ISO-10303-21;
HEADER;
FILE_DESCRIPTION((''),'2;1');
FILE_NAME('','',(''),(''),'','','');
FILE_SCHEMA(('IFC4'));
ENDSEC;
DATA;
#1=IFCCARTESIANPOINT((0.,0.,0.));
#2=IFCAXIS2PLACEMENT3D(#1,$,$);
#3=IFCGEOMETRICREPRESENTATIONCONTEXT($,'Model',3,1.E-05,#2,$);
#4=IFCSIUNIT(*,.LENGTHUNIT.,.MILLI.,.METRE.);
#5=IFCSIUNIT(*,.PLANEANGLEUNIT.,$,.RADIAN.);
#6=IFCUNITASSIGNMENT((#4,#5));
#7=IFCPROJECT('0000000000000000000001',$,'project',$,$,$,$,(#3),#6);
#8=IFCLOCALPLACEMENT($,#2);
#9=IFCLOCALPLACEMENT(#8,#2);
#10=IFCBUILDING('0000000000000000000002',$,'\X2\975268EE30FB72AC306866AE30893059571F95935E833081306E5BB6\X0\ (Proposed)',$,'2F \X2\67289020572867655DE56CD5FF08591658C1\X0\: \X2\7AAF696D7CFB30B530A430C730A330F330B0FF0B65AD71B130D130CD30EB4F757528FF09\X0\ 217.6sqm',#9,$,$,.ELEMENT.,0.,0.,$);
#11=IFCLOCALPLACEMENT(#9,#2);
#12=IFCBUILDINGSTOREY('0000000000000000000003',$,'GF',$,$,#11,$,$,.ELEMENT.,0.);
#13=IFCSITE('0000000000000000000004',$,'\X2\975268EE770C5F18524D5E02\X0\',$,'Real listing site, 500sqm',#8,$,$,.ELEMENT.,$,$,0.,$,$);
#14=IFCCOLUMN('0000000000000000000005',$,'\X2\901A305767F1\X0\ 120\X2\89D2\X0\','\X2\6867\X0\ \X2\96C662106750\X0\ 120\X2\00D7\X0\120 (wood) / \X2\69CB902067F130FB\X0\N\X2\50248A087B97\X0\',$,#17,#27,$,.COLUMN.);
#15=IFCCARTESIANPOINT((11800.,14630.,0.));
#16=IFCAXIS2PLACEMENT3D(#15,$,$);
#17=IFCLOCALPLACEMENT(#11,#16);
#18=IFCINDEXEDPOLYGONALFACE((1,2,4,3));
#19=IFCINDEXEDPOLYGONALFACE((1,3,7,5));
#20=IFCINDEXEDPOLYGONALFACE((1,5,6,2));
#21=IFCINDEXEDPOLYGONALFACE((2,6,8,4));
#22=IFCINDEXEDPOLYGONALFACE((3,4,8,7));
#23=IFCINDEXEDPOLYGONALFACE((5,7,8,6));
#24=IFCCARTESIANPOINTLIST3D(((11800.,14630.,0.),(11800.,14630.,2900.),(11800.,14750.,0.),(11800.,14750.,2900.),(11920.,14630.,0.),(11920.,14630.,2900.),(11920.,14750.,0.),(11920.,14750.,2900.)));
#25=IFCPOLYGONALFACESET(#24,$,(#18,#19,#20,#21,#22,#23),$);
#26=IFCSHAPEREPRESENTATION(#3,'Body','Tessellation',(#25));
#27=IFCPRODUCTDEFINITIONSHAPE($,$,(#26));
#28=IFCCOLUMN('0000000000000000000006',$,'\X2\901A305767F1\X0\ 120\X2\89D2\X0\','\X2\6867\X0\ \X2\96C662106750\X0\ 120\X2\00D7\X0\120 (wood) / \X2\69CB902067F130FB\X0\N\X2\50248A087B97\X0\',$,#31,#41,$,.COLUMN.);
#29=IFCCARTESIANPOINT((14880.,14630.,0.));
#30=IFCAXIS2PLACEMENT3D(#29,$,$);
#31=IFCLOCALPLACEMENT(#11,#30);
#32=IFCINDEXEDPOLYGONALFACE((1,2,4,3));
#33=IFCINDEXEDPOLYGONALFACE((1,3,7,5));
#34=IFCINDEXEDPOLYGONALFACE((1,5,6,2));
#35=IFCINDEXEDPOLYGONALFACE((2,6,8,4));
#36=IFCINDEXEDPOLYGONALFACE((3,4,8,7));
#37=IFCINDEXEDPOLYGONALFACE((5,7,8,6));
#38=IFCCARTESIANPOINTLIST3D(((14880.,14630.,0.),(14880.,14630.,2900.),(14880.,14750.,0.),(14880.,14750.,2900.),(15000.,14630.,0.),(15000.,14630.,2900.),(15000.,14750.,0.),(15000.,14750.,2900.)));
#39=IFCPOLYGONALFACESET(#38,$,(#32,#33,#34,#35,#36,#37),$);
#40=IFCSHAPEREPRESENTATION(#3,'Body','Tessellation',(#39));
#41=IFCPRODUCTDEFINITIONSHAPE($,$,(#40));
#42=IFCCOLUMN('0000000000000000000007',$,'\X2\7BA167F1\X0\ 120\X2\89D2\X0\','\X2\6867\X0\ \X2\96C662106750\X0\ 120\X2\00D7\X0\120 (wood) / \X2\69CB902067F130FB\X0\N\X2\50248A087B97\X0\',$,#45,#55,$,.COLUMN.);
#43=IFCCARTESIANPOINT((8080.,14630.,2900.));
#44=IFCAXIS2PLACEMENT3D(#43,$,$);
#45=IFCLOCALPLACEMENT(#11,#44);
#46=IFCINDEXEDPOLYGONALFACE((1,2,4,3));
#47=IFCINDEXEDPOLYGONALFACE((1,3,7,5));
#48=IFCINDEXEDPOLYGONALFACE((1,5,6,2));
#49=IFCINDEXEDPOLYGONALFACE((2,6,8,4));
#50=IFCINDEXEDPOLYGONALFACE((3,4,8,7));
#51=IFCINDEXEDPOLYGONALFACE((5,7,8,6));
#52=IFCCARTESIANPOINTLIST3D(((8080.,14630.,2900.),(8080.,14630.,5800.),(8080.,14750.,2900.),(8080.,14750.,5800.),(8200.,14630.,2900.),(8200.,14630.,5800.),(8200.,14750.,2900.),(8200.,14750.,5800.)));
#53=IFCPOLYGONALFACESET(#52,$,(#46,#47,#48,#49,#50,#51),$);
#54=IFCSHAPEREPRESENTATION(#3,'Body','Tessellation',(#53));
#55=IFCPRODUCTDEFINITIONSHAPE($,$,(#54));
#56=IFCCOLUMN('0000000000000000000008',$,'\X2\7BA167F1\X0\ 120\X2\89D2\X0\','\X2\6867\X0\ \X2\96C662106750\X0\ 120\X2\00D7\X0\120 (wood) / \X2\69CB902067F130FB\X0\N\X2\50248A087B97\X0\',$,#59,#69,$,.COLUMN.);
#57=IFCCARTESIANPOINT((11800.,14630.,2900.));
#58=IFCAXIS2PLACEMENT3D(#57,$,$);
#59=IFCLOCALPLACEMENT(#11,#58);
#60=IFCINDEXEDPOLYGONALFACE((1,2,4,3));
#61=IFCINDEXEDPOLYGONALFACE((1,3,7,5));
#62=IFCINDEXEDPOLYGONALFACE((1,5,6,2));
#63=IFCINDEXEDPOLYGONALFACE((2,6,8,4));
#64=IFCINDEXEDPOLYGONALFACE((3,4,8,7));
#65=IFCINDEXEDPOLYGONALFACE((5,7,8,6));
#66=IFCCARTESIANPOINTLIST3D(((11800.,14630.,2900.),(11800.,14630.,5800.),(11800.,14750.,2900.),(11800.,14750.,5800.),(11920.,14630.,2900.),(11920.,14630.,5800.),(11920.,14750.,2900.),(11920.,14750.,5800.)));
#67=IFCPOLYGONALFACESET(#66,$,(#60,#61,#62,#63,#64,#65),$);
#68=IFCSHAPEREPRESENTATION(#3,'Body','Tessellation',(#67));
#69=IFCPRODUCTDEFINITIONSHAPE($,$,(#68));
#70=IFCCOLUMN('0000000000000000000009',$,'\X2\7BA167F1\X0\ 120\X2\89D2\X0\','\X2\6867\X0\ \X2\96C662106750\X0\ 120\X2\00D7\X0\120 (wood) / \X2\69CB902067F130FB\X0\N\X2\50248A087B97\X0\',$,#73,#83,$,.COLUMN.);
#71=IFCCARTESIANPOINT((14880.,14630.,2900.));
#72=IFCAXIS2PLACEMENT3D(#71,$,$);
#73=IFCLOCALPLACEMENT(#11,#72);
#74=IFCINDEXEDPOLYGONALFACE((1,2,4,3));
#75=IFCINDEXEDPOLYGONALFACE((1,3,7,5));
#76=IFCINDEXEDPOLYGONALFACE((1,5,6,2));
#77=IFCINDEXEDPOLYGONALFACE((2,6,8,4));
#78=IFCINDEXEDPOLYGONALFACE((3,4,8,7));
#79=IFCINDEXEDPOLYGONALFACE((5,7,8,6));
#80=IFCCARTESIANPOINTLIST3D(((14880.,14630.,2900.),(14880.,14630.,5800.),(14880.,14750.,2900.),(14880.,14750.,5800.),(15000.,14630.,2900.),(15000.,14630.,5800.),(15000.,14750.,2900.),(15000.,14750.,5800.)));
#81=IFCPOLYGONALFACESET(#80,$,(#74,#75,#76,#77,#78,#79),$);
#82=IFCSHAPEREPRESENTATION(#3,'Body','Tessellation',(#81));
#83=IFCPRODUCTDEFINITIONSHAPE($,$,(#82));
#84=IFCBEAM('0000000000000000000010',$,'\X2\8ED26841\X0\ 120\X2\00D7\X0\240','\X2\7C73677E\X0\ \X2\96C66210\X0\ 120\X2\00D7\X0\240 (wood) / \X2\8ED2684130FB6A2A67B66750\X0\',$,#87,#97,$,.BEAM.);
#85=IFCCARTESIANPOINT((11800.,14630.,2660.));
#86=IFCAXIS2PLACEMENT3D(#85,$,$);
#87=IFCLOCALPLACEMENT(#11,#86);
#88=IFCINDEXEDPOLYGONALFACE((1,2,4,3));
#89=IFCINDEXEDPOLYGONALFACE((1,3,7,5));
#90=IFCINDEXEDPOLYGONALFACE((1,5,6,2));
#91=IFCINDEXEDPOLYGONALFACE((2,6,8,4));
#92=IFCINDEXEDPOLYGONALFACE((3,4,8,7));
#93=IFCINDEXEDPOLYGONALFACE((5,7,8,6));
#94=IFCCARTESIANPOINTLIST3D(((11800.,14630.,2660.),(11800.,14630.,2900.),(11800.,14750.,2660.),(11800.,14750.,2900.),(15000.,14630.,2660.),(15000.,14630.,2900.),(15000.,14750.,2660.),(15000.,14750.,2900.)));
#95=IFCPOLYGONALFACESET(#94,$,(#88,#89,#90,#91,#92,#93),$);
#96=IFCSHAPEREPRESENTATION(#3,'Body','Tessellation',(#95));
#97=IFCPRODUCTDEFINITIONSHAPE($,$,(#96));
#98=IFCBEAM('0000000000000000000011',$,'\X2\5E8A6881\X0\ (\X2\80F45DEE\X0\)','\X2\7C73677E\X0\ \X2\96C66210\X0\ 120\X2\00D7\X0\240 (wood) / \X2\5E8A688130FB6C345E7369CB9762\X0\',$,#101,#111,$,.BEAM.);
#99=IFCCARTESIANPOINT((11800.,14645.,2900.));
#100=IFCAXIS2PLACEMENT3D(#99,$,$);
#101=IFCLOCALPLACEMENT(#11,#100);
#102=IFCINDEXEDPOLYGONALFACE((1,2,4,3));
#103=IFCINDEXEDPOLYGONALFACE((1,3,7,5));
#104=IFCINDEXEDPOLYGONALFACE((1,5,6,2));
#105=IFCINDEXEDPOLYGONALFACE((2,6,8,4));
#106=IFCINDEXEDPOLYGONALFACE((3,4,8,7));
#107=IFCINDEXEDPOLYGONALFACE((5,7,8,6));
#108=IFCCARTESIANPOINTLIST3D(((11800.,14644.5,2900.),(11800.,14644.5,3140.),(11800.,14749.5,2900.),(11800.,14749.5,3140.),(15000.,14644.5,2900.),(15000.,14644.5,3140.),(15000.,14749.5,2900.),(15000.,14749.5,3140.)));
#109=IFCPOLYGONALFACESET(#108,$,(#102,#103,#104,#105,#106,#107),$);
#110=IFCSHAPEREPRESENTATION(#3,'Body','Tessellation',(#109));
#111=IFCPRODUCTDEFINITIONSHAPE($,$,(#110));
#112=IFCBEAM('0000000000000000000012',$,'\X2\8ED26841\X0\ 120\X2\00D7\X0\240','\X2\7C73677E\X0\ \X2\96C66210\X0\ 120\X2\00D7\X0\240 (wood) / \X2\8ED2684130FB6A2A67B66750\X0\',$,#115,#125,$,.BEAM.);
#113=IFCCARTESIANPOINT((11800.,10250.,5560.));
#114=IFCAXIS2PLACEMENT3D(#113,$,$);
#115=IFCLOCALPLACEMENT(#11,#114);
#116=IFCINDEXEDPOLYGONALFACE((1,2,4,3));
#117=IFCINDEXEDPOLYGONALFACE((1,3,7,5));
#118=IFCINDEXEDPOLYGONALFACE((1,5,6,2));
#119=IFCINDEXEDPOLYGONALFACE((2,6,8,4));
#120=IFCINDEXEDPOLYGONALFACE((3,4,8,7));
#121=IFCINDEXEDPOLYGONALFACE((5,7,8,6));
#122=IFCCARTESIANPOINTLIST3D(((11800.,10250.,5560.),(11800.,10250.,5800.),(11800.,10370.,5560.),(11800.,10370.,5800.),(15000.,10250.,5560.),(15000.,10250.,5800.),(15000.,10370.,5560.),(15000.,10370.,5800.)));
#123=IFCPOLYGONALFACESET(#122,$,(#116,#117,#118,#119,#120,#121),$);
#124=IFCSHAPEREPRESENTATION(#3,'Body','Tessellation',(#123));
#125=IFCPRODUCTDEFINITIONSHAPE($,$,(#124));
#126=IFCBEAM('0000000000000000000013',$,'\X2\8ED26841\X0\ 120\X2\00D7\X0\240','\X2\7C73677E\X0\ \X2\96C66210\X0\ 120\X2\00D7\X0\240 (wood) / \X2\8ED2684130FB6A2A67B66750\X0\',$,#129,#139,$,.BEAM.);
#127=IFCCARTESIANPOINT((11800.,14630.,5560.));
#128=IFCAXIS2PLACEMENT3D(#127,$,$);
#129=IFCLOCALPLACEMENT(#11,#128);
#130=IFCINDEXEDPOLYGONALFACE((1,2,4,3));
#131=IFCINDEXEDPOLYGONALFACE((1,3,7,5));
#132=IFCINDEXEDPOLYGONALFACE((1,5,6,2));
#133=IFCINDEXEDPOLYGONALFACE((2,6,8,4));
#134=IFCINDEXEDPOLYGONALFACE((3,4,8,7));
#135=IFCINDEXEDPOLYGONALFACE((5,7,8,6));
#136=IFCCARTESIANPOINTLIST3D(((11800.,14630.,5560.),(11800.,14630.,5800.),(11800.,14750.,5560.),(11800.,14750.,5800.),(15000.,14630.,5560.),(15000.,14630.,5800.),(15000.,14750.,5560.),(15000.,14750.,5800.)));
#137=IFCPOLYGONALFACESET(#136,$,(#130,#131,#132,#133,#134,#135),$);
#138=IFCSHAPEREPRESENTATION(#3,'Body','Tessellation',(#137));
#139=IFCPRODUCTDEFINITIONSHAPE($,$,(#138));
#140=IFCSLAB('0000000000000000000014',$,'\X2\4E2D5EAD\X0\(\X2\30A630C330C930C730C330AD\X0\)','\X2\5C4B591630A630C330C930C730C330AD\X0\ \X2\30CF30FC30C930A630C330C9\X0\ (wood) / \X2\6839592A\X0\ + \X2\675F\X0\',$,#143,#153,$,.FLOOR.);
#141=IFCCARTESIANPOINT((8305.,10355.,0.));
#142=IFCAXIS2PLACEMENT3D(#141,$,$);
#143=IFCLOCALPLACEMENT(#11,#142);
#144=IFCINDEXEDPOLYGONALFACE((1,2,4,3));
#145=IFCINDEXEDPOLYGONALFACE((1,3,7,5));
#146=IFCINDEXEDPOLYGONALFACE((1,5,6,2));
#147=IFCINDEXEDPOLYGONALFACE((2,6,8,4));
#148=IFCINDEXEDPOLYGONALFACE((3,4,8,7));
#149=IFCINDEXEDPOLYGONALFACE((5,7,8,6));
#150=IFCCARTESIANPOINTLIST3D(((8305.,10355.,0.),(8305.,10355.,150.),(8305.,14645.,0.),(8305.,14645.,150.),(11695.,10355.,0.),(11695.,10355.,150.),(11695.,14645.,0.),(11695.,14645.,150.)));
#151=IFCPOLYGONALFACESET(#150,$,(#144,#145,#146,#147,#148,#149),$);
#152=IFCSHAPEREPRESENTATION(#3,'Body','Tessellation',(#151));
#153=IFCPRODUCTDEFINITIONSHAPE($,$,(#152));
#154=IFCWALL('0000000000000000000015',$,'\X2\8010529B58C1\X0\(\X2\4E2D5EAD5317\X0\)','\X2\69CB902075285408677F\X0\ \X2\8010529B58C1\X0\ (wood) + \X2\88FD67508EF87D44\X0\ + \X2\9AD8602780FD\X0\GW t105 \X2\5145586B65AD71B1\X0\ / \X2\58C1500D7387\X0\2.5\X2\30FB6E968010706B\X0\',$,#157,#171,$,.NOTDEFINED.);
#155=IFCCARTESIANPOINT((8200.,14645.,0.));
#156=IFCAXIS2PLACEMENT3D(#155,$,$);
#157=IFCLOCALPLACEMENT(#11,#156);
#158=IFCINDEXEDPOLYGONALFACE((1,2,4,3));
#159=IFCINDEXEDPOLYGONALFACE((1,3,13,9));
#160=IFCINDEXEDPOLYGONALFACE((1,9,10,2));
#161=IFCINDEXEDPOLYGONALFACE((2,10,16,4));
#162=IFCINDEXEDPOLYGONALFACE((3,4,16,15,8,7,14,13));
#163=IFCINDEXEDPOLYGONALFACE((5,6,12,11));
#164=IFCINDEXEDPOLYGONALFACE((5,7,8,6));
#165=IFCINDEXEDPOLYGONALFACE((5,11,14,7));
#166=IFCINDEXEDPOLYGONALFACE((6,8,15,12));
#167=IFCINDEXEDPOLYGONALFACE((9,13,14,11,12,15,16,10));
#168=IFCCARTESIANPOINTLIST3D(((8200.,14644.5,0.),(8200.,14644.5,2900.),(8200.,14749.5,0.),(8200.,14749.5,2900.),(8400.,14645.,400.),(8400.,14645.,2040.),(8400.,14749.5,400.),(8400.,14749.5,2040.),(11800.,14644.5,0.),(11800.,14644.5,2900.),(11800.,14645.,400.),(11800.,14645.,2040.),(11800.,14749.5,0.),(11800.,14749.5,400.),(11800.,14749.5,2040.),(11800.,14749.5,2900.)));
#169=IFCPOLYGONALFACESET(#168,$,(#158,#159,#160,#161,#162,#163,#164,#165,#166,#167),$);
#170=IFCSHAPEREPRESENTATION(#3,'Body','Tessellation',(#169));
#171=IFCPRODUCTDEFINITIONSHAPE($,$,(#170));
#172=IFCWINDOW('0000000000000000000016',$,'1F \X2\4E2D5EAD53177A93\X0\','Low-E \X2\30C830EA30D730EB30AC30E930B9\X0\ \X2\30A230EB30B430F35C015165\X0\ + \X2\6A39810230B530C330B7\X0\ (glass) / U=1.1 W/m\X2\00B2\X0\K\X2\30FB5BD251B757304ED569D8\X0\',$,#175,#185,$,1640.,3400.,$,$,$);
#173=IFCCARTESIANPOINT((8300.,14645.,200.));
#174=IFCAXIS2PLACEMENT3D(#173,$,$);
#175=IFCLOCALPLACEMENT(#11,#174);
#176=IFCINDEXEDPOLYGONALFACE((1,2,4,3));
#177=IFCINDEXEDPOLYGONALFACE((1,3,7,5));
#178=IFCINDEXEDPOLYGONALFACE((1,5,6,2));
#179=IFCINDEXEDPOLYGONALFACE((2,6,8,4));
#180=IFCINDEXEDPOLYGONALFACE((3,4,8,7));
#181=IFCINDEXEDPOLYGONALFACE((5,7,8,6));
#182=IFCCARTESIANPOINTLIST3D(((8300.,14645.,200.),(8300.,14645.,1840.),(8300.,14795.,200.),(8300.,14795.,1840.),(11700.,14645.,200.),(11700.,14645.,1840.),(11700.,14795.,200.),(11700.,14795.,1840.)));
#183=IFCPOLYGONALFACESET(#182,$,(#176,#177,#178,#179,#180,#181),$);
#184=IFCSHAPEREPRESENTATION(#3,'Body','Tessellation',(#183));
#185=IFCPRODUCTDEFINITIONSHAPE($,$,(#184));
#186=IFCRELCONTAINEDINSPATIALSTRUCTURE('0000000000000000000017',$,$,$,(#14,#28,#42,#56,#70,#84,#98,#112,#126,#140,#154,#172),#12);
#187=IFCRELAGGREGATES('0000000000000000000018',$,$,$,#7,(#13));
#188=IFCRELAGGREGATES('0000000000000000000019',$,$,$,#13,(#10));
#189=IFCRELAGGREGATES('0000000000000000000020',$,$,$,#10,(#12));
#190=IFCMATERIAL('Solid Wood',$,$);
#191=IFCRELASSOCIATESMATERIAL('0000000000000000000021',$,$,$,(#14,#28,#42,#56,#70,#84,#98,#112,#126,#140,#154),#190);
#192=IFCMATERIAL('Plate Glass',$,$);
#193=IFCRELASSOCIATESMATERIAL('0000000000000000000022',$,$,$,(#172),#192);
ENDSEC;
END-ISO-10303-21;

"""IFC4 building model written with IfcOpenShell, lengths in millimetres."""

from ifc_helpers import new_model, si_unit, frame, frame_2d, origin, place, context, project, spatial, rectangle, extrude, material, element, fill, save


model = new_model("IFC4")

# Units and contexts
model_context = context("Model", 3, precision=1e-05, world=origin())
ifc_project = project(units=[si_unit("LENGTHUNIT", "METRE", prefix="MILLI"), si_unit("PLANEANGLEUNIT", "RADIAN")], contexts=[model_context])

# Site, building, storey
site_placement = place(None, origin())
site = spatial("IfcSite", under=ifc_project, at=site_placement, Name="青森県弘前市", ObjectType="Real listing site, 500sqm", CompositionType="ELEMENT", RefElevation=0.0)
building_placement = place(site_placement, origin())
building = spatial("IfcBuilding", under=site, at=building_placement, Name="青森・犬と暮らす土間広めの家 (Proposed)", ObjectType="2F 木造在来工法（外壁: 窯業系サイディング＋断熱パネル併用） 217.6sqm", CompositionType="ELEMENT", ElevationOfRefHeight=0.0, ElevationOfTerrain=0.0)
storey_placement = place(building_placement, origin())
storey = spatial("IfcBuildingStorey", under=building, at=storey_placement, Name="GF", CompositionType="ELEMENT", Elevation=0.0)

# Columns
ifc_material_1 = material(Name="Solid Wood")
column_1_placement = place(storey_placement, frame((11800.0, 14630.0, 0.0)))
element("IfcColumn", 1, at=column_1_placement, inside=storey, material=ifc_material_1, Name="通し柱 120角", Description="桧 集成材 120×120 (wood) / 構造柱・N値計算", PredefinedType="COLUMN", context=model_context, shape_type="SweptSolid", body=[
    extrude(rectangle(XDim=120.0, YDim=120.0, at=frame_2d((60.0, 60.0))), frame((11800.0, 14630.0, 0.0)), (0.0, 0.0, 1.0), 2900.0),
])
column_2_placement = place(storey_placement, frame((14880.0, 14630.0, 0.0)))
element("IfcColumn", 2, at=column_2_placement, inside=storey, material=ifc_material_1, Name="通し柱 120角", Description="桧 集成材 120×120 (wood) / 構造柱・N値計算", PredefinedType="COLUMN", context=model_context, shape_type="SweptSolid", body=[
    extrude(rectangle(XDim=120.0, YDim=120.0, at=frame_2d((60.0, 60.0))), frame((14880.0, 14630.0, 0.0)), (0.0, 0.0, 1.0), 2900.0),
])
column_3_placement = place(storey_placement, frame((8080.0, 14630.0, 2900.0)))
element("IfcColumn", 3, at=column_3_placement, inside=storey, material=ifc_material_1, Name="管柱 120角", Description="桧 集成材 120×120 (wood) / 構造柱・N値計算", PredefinedType="COLUMN", context=model_context, shape_type="SweptSolid", body=[
    extrude(rectangle(XDim=120.0, YDim=120.0, at=frame_2d((60.0, 60.0))), frame((8080.0, 14630.0, 2900.0)), (0.0, 0.0, 1.0), 2900.0),
])
column_4_placement = place(storey_placement, frame((11800.0, 14630.0, 2900.0)))
element("IfcColumn", 4, at=column_4_placement, inside=storey, material=ifc_material_1, Name="管柱 120角", Description="桧 集成材 120×120 (wood) / 構造柱・N値計算", PredefinedType="COLUMN", context=model_context, shape_type="SweptSolid", body=[
    extrude(rectangle(XDim=120.0, YDim=120.0, at=frame_2d((60.0, 60.0))), frame((11800.0, 14630.0, 2900.0)), (0.0, 0.0, 1.0), 2900.0),
])
column_5_placement = place(storey_placement, frame((14880.0, 14630.0, 2900.0)))
element("IfcColumn", 5, at=column_5_placement, inside=storey, material=ifc_material_1, Name="管柱 120角", Description="桧 集成材 120×120 (wood) / 構造柱・N値計算", PredefinedType="COLUMN", context=model_context, shape_type="SweptSolid", body=[
    extrude(rectangle(XDim=120.0, YDim=120.0, at=frame_2d((60.0, 60.0))), frame((14880.0, 14630.0, 2900.0)), (0.0, 0.0, 1.0), 2900.0),
])

# Beams
beam_1_placement = place(storey_placement, frame((11800.0, 14630.0, 2660.0)))
element("IfcBeam", 6, at=beam_1_placement, inside=storey, material=ifc_material_1, Name="軒桁 120×240", Description="米松 集成 120×240 (wood) / 軒桁・横架材", PredefinedType="BEAM", context=model_context, shape_type="SweptSolid", body=[
    extrude(rectangle(XDim=3200.0, YDim=120.0, at=frame_2d((1600.0, 60.0))), frame((11800.0, 14630.0, 2660.0)), (0.0, 0.0, 1.0), 240.0),
])
beam_2_placement = place(storey_placement, frame((11800.0, 14645.0, 2900.0)))
element("IfcBeam", 7, at=beam_2_placement, inside=storey, material=ifc_material_1, Name="床梁 (胴差)", Description="米松 集成 120×240 (wood) / 床梁・水平構面", PredefinedType="BEAM", context=model_context, shape_type="SweptSolid", body=[
    extrude(rectangle(XDim=3200.0, YDim=105.0, at=frame_2d((1600.0, 52.0))), frame((11800.0, 14645.0, 2900.0)), (0.0, 0.0, 1.0), 240.0),
])
beam_3_placement = place(storey_placement, frame((11800.0, 10250.0, 5560.0)))
element("IfcBeam", 8, at=beam_3_placement, inside=storey, material=ifc_material_1, Name="軒桁 120×240", Description="米松 集成 120×240 (wood) / 軒桁・横架材", PredefinedType="BEAM", context=model_context, shape_type="SweptSolid", body=[
    extrude(rectangle(XDim=3200.0, YDim=120.0, at=frame_2d((1600.0, 60.0))), frame((11800.0, 10250.0, 5560.0)), (0.0, 0.0, 1.0), 240.0),
])
beam_4_placement = place(storey_placement, frame((11800.0, 14630.0, 5560.0)))
element("IfcBeam", 9, at=beam_4_placement, inside=storey, material=ifc_material_1, Name="軒桁 120×240", Description="米松 集成 120×240 (wood) / 軒桁・横架材", PredefinedType="BEAM", context=model_context, shape_type="SweptSolid", body=[
    extrude(rectangle(XDim=3200.0, YDim=120.0, at=frame_2d((1600.0, 60.0))), frame((11800.0, 14630.0, 5560.0)), (0.0, 0.0, 1.0), 240.0),
])

# Slab
slab_placement = place(storey_placement, frame((8305.0, 10355.0, 0.0)))
element("IfcSlab", 10, at=slab_placement, inside=storey, material=ifc_material_1, Name="中庭(ウッドデッキ)", Description="屋外ウッドデッキ ハードウッド (wood) / 根太 + 束", PredefinedType="FLOOR", context=model_context, shape_type="SweptSolid", body=[
    extrude(rectangle(XDim=3390.0, YDim=4290.0, at=frame_2d((1695.0, 2145.0))), frame((8305.0, 10355.0, 0.0)), (0.0, 0.0, 1.0), 150.0),
])

# Wall, opening, window
wall_1_placement = place(storey_placement, frame((8200.0, 14645.0, 0.0)))
wall_1 = element("IfcWall", 11, at=wall_1_placement, inside=storey, material=ifc_material_1, Name="耐力壁(中庭北)", Description="構造用合板 耐力壁 (wood) + 製材軸組 + 高性能GW t105 充填断熱 / 壁倍率2.5・準耐火", PredefinedType="NOTDEFINED", context=model_context, shape_type="SweptSolid", body=[
    extrude(rectangle(XDim=3600.0, YDim=105.0, at=frame_2d((1800.0, 52.0))), frame((8200.0, 14645.0, 0.0)), (0.0, 0.0, 1.0), 2900.0),
])
opening_1_placement = place(storey_placement, frame((8300.0, 14645.0, 200.0)))
opening_1 = element("IfcOpeningElement", 12, at=opening_1_placement, cuts=wall_1, PredefinedType="NOTDEFINED", context=model_context, shape_type="SweptSolid", body=[
    extrude(rectangle(XDim=3400.0, YDim=150.0, at=frame_2d((1700.0, 75.0))), frame((8300.0, 14645.0, 200.0)), (0.0, 0.0, 1.0), 1640.0),
])
ifc_material_2 = material(Name="Plate Glass")
window_1_placement = place(storey_placement, frame((8300.0, 14645.0, 200.0)))
window_1 = element("IfcWindow", 13, at=window_1_placement, inside=storey, material=ifc_material_2, Name="1F 中庭北窓", Description="Low-E トリプルガラス アルゴン封入 + 樹脂サッシ (glass) / U=1.1 W/m²K・寒冷地仕様", OverallHeight=1640.0, OverallWidth=3400.0, context=model_context, shape_type="SweptSolid", body=[
    extrude(rectangle(XDim=3400.0, YDim=150.0, at=frame_2d((1700.0, 75.0))), frame((8300.0, 14645.0, 200.0)), (0.0, 0.0, 1.0), 1640.0),
])
fill(opening_1, window_1)

save(model, "model.ifc")
